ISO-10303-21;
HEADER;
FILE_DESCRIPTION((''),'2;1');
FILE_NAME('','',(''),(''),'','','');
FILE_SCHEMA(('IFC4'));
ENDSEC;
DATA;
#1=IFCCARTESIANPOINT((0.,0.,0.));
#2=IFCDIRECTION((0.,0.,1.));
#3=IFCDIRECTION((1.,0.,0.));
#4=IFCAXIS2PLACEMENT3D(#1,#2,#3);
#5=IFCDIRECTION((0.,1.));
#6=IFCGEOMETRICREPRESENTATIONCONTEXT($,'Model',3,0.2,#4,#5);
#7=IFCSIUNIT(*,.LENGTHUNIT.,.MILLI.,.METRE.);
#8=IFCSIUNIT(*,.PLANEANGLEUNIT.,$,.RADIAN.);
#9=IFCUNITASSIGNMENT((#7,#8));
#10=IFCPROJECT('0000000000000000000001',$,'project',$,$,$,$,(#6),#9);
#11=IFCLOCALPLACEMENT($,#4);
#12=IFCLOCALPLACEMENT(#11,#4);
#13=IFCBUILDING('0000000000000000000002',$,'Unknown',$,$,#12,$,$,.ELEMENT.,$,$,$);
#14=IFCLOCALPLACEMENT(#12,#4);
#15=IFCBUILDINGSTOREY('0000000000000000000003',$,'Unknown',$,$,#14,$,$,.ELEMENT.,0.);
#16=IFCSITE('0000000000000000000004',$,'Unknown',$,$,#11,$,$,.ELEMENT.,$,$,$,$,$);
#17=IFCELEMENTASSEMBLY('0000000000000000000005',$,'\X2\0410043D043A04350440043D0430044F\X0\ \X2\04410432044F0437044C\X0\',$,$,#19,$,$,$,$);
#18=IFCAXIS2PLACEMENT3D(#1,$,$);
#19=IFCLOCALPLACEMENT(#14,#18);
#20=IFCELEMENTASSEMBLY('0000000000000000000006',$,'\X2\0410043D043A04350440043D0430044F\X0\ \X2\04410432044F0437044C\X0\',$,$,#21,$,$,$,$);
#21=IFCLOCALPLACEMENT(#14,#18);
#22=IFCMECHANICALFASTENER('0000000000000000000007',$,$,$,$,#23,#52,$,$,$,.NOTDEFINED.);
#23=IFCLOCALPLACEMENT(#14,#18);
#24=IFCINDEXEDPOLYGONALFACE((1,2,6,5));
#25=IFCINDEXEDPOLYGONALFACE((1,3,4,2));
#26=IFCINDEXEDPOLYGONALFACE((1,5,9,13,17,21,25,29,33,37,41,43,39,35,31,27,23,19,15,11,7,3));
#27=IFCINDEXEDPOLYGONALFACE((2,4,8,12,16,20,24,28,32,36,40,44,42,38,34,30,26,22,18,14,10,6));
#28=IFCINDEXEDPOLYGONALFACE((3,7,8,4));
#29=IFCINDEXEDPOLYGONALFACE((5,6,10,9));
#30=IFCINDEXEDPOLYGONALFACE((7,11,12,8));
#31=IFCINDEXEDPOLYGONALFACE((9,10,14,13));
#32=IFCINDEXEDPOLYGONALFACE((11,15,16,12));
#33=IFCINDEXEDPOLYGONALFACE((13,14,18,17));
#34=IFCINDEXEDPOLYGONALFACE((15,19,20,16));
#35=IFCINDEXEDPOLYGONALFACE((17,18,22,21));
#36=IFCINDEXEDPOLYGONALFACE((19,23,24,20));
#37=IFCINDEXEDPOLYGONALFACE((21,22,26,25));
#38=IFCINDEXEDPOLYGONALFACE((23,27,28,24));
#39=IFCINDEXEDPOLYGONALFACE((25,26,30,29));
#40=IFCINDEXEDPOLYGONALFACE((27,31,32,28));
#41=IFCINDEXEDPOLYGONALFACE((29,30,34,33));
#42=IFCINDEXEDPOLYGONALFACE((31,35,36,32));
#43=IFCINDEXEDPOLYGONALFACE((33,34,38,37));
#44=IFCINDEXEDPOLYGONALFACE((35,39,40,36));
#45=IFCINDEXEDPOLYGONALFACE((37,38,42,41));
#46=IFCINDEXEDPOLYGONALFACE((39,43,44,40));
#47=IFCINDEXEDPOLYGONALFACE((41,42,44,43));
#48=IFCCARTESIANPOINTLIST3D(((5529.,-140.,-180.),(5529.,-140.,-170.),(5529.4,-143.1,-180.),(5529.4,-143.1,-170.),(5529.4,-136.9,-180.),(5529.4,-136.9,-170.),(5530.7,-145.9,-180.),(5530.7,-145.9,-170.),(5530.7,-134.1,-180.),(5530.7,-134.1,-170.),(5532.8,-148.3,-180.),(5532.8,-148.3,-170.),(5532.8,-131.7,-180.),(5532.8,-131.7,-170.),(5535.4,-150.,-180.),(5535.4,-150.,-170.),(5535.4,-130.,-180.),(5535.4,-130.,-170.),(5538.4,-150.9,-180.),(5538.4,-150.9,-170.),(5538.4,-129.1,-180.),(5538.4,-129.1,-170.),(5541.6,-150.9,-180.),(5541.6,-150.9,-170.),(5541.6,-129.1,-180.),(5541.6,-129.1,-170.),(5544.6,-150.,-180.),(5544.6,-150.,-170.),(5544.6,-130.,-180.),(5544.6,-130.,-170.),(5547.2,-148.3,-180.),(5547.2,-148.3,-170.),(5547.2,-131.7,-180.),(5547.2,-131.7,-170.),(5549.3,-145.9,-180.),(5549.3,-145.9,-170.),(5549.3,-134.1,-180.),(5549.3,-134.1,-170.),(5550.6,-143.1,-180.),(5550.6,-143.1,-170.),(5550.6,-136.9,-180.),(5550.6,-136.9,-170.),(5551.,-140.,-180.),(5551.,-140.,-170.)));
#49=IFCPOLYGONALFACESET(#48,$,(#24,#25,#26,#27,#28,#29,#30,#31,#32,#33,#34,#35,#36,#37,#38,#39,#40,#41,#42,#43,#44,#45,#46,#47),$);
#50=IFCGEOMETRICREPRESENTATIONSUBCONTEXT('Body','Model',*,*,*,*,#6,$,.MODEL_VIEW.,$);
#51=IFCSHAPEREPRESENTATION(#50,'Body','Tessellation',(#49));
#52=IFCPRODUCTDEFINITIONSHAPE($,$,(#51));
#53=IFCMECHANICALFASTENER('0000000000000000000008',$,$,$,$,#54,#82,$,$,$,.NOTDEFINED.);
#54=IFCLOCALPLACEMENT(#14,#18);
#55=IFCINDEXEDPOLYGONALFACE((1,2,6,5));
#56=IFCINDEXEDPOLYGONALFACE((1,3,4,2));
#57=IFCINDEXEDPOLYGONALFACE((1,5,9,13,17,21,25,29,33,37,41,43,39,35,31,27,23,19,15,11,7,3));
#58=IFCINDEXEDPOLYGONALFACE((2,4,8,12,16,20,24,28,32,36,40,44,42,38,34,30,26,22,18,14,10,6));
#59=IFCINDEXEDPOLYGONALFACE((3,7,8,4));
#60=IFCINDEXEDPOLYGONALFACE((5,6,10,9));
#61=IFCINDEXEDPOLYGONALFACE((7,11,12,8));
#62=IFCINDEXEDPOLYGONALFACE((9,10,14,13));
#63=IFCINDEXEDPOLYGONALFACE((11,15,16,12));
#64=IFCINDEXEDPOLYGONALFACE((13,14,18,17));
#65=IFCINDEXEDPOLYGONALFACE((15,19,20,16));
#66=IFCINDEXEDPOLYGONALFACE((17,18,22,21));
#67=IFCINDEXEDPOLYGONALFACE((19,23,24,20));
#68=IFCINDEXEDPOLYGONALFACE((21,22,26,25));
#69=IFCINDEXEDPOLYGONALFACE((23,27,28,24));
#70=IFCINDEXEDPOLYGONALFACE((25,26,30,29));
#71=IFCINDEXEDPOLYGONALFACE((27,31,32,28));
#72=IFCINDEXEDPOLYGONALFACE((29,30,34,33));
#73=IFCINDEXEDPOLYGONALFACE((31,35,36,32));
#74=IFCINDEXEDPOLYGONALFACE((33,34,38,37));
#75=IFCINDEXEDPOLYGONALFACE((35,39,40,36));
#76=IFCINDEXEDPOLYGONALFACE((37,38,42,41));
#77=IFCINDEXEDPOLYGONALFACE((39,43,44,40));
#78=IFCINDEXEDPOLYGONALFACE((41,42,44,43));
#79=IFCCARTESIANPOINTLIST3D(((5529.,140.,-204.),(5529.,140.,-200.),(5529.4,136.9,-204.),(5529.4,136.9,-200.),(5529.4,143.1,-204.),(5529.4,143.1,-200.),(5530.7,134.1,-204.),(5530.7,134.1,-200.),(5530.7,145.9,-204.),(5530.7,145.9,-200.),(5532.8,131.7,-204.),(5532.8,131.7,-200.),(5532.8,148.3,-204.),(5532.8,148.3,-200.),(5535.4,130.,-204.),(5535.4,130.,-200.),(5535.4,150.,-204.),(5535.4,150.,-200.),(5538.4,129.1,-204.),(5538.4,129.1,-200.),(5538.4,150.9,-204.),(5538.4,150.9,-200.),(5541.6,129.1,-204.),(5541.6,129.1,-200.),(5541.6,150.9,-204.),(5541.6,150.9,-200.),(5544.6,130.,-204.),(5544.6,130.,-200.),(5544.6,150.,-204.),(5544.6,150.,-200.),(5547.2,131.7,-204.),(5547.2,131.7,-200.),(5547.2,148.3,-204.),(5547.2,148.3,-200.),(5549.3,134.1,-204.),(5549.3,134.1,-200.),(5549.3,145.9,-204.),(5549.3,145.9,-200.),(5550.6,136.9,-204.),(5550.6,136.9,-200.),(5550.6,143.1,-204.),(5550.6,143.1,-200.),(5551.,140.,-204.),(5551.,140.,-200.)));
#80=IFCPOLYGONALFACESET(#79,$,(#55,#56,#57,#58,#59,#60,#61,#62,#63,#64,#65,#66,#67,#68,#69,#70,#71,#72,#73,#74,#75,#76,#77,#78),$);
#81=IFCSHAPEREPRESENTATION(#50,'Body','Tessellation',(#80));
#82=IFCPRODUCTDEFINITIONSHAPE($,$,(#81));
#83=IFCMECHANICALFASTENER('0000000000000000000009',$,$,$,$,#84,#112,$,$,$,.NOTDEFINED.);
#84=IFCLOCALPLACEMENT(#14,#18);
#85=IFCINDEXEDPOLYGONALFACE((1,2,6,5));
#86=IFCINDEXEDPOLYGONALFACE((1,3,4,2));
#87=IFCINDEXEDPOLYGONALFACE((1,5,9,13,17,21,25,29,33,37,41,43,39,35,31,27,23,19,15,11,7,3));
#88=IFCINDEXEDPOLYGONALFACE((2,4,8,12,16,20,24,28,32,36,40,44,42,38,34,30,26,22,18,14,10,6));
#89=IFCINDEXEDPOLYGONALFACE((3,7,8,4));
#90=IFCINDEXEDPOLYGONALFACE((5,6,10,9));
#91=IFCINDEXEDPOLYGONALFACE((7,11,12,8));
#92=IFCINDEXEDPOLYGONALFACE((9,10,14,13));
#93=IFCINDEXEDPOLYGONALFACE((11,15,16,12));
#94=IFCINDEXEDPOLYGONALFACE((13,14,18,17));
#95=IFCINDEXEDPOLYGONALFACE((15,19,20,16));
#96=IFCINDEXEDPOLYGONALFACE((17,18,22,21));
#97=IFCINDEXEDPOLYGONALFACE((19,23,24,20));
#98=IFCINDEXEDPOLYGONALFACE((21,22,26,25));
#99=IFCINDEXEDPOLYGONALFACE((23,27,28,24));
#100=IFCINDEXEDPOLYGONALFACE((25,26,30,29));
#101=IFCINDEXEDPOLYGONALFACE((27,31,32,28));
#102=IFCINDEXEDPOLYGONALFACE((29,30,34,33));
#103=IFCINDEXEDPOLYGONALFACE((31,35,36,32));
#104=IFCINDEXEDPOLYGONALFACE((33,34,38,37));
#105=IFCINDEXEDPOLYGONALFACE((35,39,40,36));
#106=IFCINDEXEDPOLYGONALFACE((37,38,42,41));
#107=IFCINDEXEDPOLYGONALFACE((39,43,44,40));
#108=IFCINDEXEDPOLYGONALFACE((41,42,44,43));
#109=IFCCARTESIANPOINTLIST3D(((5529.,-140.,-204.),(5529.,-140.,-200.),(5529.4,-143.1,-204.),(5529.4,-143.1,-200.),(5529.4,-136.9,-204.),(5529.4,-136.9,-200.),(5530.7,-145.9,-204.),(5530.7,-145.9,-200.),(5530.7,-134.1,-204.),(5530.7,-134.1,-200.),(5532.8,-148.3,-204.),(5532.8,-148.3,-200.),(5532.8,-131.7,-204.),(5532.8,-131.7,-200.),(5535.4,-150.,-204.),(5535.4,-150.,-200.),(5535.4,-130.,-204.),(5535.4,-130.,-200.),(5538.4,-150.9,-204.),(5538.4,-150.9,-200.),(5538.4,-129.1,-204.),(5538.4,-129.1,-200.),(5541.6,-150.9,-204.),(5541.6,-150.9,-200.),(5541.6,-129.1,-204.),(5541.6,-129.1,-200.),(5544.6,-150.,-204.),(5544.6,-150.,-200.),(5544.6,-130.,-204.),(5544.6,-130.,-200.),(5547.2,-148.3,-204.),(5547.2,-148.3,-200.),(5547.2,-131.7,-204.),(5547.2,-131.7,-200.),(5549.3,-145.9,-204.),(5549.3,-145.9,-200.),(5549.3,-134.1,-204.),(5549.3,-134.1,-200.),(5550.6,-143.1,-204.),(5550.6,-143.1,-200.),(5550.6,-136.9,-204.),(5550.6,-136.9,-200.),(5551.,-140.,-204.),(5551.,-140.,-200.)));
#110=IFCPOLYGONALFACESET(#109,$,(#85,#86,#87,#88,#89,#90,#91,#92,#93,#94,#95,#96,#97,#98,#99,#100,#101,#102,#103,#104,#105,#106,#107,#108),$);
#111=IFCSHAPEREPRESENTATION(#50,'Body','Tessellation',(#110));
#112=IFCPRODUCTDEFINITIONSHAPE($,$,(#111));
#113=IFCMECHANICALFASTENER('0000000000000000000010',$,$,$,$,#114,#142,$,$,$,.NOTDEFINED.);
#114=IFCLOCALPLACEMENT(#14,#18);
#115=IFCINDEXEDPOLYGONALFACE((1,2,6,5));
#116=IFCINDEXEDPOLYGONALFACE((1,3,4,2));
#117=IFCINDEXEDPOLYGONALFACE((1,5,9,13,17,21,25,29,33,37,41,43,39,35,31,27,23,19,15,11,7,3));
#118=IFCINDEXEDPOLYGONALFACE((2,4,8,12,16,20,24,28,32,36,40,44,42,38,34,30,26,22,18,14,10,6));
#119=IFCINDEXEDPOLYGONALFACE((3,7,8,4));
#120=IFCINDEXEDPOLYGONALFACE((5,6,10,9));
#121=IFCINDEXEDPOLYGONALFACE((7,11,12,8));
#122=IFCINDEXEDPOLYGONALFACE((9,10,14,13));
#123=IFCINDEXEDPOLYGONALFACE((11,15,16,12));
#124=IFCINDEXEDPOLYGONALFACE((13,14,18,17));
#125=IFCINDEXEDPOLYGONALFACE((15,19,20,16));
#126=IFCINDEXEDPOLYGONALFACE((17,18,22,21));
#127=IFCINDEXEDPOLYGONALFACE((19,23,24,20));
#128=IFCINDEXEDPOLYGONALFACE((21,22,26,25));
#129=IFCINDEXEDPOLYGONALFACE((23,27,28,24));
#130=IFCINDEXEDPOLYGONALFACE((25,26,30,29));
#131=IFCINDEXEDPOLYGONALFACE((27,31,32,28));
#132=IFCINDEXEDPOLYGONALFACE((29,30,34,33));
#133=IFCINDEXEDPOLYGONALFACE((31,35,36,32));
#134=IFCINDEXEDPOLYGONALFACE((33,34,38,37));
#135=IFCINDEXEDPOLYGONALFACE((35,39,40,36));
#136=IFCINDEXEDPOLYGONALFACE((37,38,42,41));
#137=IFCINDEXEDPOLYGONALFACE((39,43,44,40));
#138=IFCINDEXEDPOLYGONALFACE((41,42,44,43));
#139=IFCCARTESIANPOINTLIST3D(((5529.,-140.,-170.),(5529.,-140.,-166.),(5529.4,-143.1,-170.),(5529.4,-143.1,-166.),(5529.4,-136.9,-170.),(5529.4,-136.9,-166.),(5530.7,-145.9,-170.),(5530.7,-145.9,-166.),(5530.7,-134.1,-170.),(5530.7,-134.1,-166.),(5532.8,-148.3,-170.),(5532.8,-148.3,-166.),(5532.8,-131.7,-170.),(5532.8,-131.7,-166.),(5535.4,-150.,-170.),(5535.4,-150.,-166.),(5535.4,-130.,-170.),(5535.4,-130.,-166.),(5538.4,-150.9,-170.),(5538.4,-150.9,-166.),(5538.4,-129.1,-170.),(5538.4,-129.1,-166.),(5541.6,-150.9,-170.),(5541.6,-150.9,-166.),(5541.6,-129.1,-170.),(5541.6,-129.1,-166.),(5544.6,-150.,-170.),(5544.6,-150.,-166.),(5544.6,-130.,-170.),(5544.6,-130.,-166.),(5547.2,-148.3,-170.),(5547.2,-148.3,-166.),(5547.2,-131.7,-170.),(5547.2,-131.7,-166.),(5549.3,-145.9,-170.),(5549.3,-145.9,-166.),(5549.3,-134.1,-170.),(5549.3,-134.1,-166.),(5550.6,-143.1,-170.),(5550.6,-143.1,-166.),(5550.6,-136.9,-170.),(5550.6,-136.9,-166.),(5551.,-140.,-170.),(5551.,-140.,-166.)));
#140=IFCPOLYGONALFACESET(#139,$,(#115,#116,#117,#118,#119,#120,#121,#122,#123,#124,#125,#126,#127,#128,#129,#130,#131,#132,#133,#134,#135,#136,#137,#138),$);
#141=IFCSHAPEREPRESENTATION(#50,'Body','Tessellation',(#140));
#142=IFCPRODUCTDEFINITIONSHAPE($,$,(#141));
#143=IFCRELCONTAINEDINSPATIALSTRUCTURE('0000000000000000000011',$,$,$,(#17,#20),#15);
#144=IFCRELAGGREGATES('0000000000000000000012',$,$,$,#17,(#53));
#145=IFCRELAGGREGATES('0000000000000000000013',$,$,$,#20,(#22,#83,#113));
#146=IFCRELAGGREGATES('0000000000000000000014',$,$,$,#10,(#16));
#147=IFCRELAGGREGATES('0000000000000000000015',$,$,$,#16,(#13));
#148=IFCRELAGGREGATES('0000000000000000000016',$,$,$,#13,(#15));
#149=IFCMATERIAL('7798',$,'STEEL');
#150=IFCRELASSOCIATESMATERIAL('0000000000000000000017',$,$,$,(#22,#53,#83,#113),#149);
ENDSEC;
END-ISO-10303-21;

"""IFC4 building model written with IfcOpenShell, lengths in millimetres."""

from ifc_helpers import new_model, si_unit, direction, frame, origin_with_axes, place, context, subcontext, project, spatial, arc, indexed_curve, outline, extrude, source, transform, mapped, material, element, aggregate, save


model = new_model("IFC4")

# Units and contexts
model_context = context("Model", 3, precision=0.2, world=origin_with_axes(), true_north=direction((0.0, 1.0)))
body_context = subcontext(model_context, "Body", "Model", "MODEL_VIEW")
ifc_project = project(units=[si_unit("LENGTHUNIT", "METRE", prefix="MILLI"), si_unit("PLANEANGLEUNIT", "RADIAN")], contexts=[model_context])

# Site, building, storey
site_placement = place(None, origin_with_axes())
site = spatial("IfcSite", under=ifc_project, at=site_placement, Name="Unknown", CompositionType="ELEMENT")
building_placement = place(site_placement, origin_with_axes())
building = spatial("IfcBuilding", under=site, at=building_placement, Name="Unknown", CompositionType="ELEMENT")
storey_placement = place(building_placement, origin_with_axes())
storey = spatial("IfcBuildingStorey", under=building, at=storey_placement, Name="Unknown", CompositionType="ELEMENT", Elevation=0.0)

# Element assemblies
assembly_1_placement = place(storey_placement, frame((5540.0, 140.0, -125.0), z_axis=(-1.0, 0.0, 0.0), x_axis=(0.0, 0.0, -1.0)))
assembly_1 = element("IfcElementAssembly", 1, at=assembly_1_placement, inside=storey, Name="Анкерная связь")
assembly_2_placement = place(storey_placement, frame((5540.0, -140.0, -125.0), z_axis=(1.0, 0.0, 0.0), x_axis=(0.0, 0.0, -1.0)))
assembly_2 = element("IfcElementAssembly", 2, at=assembly_2_placement, inside=storey, Name="Анкерная связь")

# Mechanical fasteners
ifc_material_1 = material(Name="7798", Category="STEEL")
shared_shape_1 = source(origin_with_axes(), body_context, "Body", "SweptSolid", [
    extrude(outline(indexed_curve([(11.0, 0.0), (0.0, 11.0), (-11.0, 0.0), (0.0, -11.0)], segments=[arc(1, 2, 3), arc(3, 4, 1)])), frame((0.0, 0.0, 0.0), z_axis=(0.0, 0.0, -1.0), x_axis=(0.0, 1.0, 0.0)), (0.0, 0.0, 1.0), 10.0),
])
mechanical_fastener_1_placement = place(assembly_2_placement, frame((55.0, 0.0, 0.0), z_axis=(1.0, 0.0, 0.0), x_axis=(0.0, 1.0, 0.0)))
mechanical_fastener_1 = element("IfcMechanicalFastener", 3, at=mechanical_fastener_1_placement, material=ifc_material_1, PredefinedType="NOTDEFINED", context=body_context, shape_type="MappedRepresentation", body=[
    mapped(shared_shape_1, transform((0.0, 0.0, 0.0))),
])
shared_shape_2 = source(origin_with_axes(), body_context, "Body", "SweptSolid", [
    extrude(outline(indexed_curve([(11.0, 0.0), (0.0, 11.0), (-11.0, 0.0), (0.0, -11.0)], segments=[arc(1, 2, 3), arc(3, 4, 1)])), frame((0.0, 0.0, 4.0), z_axis=(0.0, 0.0, -1.0), x_axis=(0.0, 1.0, 0.0)), (0.0, 0.0, 1.0), 4.0),
])
mechanical_fastener_2_placement = place(assembly_1_placement, frame((75.0, 0.0, 0.0), z_axis=(1.0, 0.0, 0.0), x_axis=(0.0, -1.0, 0.0)))
mechanical_fastener_2 = element("IfcMechanicalFastener", 4, at=mechanical_fastener_2_placement, material=ifc_material_1, PredefinedType="NOTDEFINED", context=body_context, shape_type="MappedRepresentation", body=[
    mapped(shared_shape_2, transform((0.0, 0.0, 0.0))),
])
aggregate(assembly_1, [mechanical_fastener_2])
mechanical_fastener_3_placement = place(assembly_2_placement, frame((75.0, 0.0, 0.0), z_axis=(1.0, 0.0, 0.0), x_axis=(0.0, 1.0, 0.0)))
mechanical_fastener_3 = element("IfcMechanicalFastener", 5, at=mechanical_fastener_3_placement, material=ifc_material_1, PredefinedType="NOTDEFINED", context=body_context, shape_type="MappedRepresentation", body=[
    mapped(shared_shape_2, transform((0.0, 0.0, 0.0))),
])
mechanical_fastener_4_placement = place(assembly_2_placement, frame((41.0, 0.0, 0.0), z_axis=(1.0, 0.0, 0.0), x_axis=(0.0, 1.0, 0.0)))
mechanical_fastener_4 = element("IfcMechanicalFastener", 6, at=mechanical_fastener_4_placement, material=ifc_material_1, PredefinedType="NOTDEFINED", context=body_context, shape_type="MappedRepresentation", body=[
    mapped(shared_shape_2, transform((0.0, 0.0, 0.0))),
])
aggregate(assembly_2, [mechanical_fastener_1, mechanical_fastener_3, mechanical_fastener_4])

save(model, "model.ifc")
